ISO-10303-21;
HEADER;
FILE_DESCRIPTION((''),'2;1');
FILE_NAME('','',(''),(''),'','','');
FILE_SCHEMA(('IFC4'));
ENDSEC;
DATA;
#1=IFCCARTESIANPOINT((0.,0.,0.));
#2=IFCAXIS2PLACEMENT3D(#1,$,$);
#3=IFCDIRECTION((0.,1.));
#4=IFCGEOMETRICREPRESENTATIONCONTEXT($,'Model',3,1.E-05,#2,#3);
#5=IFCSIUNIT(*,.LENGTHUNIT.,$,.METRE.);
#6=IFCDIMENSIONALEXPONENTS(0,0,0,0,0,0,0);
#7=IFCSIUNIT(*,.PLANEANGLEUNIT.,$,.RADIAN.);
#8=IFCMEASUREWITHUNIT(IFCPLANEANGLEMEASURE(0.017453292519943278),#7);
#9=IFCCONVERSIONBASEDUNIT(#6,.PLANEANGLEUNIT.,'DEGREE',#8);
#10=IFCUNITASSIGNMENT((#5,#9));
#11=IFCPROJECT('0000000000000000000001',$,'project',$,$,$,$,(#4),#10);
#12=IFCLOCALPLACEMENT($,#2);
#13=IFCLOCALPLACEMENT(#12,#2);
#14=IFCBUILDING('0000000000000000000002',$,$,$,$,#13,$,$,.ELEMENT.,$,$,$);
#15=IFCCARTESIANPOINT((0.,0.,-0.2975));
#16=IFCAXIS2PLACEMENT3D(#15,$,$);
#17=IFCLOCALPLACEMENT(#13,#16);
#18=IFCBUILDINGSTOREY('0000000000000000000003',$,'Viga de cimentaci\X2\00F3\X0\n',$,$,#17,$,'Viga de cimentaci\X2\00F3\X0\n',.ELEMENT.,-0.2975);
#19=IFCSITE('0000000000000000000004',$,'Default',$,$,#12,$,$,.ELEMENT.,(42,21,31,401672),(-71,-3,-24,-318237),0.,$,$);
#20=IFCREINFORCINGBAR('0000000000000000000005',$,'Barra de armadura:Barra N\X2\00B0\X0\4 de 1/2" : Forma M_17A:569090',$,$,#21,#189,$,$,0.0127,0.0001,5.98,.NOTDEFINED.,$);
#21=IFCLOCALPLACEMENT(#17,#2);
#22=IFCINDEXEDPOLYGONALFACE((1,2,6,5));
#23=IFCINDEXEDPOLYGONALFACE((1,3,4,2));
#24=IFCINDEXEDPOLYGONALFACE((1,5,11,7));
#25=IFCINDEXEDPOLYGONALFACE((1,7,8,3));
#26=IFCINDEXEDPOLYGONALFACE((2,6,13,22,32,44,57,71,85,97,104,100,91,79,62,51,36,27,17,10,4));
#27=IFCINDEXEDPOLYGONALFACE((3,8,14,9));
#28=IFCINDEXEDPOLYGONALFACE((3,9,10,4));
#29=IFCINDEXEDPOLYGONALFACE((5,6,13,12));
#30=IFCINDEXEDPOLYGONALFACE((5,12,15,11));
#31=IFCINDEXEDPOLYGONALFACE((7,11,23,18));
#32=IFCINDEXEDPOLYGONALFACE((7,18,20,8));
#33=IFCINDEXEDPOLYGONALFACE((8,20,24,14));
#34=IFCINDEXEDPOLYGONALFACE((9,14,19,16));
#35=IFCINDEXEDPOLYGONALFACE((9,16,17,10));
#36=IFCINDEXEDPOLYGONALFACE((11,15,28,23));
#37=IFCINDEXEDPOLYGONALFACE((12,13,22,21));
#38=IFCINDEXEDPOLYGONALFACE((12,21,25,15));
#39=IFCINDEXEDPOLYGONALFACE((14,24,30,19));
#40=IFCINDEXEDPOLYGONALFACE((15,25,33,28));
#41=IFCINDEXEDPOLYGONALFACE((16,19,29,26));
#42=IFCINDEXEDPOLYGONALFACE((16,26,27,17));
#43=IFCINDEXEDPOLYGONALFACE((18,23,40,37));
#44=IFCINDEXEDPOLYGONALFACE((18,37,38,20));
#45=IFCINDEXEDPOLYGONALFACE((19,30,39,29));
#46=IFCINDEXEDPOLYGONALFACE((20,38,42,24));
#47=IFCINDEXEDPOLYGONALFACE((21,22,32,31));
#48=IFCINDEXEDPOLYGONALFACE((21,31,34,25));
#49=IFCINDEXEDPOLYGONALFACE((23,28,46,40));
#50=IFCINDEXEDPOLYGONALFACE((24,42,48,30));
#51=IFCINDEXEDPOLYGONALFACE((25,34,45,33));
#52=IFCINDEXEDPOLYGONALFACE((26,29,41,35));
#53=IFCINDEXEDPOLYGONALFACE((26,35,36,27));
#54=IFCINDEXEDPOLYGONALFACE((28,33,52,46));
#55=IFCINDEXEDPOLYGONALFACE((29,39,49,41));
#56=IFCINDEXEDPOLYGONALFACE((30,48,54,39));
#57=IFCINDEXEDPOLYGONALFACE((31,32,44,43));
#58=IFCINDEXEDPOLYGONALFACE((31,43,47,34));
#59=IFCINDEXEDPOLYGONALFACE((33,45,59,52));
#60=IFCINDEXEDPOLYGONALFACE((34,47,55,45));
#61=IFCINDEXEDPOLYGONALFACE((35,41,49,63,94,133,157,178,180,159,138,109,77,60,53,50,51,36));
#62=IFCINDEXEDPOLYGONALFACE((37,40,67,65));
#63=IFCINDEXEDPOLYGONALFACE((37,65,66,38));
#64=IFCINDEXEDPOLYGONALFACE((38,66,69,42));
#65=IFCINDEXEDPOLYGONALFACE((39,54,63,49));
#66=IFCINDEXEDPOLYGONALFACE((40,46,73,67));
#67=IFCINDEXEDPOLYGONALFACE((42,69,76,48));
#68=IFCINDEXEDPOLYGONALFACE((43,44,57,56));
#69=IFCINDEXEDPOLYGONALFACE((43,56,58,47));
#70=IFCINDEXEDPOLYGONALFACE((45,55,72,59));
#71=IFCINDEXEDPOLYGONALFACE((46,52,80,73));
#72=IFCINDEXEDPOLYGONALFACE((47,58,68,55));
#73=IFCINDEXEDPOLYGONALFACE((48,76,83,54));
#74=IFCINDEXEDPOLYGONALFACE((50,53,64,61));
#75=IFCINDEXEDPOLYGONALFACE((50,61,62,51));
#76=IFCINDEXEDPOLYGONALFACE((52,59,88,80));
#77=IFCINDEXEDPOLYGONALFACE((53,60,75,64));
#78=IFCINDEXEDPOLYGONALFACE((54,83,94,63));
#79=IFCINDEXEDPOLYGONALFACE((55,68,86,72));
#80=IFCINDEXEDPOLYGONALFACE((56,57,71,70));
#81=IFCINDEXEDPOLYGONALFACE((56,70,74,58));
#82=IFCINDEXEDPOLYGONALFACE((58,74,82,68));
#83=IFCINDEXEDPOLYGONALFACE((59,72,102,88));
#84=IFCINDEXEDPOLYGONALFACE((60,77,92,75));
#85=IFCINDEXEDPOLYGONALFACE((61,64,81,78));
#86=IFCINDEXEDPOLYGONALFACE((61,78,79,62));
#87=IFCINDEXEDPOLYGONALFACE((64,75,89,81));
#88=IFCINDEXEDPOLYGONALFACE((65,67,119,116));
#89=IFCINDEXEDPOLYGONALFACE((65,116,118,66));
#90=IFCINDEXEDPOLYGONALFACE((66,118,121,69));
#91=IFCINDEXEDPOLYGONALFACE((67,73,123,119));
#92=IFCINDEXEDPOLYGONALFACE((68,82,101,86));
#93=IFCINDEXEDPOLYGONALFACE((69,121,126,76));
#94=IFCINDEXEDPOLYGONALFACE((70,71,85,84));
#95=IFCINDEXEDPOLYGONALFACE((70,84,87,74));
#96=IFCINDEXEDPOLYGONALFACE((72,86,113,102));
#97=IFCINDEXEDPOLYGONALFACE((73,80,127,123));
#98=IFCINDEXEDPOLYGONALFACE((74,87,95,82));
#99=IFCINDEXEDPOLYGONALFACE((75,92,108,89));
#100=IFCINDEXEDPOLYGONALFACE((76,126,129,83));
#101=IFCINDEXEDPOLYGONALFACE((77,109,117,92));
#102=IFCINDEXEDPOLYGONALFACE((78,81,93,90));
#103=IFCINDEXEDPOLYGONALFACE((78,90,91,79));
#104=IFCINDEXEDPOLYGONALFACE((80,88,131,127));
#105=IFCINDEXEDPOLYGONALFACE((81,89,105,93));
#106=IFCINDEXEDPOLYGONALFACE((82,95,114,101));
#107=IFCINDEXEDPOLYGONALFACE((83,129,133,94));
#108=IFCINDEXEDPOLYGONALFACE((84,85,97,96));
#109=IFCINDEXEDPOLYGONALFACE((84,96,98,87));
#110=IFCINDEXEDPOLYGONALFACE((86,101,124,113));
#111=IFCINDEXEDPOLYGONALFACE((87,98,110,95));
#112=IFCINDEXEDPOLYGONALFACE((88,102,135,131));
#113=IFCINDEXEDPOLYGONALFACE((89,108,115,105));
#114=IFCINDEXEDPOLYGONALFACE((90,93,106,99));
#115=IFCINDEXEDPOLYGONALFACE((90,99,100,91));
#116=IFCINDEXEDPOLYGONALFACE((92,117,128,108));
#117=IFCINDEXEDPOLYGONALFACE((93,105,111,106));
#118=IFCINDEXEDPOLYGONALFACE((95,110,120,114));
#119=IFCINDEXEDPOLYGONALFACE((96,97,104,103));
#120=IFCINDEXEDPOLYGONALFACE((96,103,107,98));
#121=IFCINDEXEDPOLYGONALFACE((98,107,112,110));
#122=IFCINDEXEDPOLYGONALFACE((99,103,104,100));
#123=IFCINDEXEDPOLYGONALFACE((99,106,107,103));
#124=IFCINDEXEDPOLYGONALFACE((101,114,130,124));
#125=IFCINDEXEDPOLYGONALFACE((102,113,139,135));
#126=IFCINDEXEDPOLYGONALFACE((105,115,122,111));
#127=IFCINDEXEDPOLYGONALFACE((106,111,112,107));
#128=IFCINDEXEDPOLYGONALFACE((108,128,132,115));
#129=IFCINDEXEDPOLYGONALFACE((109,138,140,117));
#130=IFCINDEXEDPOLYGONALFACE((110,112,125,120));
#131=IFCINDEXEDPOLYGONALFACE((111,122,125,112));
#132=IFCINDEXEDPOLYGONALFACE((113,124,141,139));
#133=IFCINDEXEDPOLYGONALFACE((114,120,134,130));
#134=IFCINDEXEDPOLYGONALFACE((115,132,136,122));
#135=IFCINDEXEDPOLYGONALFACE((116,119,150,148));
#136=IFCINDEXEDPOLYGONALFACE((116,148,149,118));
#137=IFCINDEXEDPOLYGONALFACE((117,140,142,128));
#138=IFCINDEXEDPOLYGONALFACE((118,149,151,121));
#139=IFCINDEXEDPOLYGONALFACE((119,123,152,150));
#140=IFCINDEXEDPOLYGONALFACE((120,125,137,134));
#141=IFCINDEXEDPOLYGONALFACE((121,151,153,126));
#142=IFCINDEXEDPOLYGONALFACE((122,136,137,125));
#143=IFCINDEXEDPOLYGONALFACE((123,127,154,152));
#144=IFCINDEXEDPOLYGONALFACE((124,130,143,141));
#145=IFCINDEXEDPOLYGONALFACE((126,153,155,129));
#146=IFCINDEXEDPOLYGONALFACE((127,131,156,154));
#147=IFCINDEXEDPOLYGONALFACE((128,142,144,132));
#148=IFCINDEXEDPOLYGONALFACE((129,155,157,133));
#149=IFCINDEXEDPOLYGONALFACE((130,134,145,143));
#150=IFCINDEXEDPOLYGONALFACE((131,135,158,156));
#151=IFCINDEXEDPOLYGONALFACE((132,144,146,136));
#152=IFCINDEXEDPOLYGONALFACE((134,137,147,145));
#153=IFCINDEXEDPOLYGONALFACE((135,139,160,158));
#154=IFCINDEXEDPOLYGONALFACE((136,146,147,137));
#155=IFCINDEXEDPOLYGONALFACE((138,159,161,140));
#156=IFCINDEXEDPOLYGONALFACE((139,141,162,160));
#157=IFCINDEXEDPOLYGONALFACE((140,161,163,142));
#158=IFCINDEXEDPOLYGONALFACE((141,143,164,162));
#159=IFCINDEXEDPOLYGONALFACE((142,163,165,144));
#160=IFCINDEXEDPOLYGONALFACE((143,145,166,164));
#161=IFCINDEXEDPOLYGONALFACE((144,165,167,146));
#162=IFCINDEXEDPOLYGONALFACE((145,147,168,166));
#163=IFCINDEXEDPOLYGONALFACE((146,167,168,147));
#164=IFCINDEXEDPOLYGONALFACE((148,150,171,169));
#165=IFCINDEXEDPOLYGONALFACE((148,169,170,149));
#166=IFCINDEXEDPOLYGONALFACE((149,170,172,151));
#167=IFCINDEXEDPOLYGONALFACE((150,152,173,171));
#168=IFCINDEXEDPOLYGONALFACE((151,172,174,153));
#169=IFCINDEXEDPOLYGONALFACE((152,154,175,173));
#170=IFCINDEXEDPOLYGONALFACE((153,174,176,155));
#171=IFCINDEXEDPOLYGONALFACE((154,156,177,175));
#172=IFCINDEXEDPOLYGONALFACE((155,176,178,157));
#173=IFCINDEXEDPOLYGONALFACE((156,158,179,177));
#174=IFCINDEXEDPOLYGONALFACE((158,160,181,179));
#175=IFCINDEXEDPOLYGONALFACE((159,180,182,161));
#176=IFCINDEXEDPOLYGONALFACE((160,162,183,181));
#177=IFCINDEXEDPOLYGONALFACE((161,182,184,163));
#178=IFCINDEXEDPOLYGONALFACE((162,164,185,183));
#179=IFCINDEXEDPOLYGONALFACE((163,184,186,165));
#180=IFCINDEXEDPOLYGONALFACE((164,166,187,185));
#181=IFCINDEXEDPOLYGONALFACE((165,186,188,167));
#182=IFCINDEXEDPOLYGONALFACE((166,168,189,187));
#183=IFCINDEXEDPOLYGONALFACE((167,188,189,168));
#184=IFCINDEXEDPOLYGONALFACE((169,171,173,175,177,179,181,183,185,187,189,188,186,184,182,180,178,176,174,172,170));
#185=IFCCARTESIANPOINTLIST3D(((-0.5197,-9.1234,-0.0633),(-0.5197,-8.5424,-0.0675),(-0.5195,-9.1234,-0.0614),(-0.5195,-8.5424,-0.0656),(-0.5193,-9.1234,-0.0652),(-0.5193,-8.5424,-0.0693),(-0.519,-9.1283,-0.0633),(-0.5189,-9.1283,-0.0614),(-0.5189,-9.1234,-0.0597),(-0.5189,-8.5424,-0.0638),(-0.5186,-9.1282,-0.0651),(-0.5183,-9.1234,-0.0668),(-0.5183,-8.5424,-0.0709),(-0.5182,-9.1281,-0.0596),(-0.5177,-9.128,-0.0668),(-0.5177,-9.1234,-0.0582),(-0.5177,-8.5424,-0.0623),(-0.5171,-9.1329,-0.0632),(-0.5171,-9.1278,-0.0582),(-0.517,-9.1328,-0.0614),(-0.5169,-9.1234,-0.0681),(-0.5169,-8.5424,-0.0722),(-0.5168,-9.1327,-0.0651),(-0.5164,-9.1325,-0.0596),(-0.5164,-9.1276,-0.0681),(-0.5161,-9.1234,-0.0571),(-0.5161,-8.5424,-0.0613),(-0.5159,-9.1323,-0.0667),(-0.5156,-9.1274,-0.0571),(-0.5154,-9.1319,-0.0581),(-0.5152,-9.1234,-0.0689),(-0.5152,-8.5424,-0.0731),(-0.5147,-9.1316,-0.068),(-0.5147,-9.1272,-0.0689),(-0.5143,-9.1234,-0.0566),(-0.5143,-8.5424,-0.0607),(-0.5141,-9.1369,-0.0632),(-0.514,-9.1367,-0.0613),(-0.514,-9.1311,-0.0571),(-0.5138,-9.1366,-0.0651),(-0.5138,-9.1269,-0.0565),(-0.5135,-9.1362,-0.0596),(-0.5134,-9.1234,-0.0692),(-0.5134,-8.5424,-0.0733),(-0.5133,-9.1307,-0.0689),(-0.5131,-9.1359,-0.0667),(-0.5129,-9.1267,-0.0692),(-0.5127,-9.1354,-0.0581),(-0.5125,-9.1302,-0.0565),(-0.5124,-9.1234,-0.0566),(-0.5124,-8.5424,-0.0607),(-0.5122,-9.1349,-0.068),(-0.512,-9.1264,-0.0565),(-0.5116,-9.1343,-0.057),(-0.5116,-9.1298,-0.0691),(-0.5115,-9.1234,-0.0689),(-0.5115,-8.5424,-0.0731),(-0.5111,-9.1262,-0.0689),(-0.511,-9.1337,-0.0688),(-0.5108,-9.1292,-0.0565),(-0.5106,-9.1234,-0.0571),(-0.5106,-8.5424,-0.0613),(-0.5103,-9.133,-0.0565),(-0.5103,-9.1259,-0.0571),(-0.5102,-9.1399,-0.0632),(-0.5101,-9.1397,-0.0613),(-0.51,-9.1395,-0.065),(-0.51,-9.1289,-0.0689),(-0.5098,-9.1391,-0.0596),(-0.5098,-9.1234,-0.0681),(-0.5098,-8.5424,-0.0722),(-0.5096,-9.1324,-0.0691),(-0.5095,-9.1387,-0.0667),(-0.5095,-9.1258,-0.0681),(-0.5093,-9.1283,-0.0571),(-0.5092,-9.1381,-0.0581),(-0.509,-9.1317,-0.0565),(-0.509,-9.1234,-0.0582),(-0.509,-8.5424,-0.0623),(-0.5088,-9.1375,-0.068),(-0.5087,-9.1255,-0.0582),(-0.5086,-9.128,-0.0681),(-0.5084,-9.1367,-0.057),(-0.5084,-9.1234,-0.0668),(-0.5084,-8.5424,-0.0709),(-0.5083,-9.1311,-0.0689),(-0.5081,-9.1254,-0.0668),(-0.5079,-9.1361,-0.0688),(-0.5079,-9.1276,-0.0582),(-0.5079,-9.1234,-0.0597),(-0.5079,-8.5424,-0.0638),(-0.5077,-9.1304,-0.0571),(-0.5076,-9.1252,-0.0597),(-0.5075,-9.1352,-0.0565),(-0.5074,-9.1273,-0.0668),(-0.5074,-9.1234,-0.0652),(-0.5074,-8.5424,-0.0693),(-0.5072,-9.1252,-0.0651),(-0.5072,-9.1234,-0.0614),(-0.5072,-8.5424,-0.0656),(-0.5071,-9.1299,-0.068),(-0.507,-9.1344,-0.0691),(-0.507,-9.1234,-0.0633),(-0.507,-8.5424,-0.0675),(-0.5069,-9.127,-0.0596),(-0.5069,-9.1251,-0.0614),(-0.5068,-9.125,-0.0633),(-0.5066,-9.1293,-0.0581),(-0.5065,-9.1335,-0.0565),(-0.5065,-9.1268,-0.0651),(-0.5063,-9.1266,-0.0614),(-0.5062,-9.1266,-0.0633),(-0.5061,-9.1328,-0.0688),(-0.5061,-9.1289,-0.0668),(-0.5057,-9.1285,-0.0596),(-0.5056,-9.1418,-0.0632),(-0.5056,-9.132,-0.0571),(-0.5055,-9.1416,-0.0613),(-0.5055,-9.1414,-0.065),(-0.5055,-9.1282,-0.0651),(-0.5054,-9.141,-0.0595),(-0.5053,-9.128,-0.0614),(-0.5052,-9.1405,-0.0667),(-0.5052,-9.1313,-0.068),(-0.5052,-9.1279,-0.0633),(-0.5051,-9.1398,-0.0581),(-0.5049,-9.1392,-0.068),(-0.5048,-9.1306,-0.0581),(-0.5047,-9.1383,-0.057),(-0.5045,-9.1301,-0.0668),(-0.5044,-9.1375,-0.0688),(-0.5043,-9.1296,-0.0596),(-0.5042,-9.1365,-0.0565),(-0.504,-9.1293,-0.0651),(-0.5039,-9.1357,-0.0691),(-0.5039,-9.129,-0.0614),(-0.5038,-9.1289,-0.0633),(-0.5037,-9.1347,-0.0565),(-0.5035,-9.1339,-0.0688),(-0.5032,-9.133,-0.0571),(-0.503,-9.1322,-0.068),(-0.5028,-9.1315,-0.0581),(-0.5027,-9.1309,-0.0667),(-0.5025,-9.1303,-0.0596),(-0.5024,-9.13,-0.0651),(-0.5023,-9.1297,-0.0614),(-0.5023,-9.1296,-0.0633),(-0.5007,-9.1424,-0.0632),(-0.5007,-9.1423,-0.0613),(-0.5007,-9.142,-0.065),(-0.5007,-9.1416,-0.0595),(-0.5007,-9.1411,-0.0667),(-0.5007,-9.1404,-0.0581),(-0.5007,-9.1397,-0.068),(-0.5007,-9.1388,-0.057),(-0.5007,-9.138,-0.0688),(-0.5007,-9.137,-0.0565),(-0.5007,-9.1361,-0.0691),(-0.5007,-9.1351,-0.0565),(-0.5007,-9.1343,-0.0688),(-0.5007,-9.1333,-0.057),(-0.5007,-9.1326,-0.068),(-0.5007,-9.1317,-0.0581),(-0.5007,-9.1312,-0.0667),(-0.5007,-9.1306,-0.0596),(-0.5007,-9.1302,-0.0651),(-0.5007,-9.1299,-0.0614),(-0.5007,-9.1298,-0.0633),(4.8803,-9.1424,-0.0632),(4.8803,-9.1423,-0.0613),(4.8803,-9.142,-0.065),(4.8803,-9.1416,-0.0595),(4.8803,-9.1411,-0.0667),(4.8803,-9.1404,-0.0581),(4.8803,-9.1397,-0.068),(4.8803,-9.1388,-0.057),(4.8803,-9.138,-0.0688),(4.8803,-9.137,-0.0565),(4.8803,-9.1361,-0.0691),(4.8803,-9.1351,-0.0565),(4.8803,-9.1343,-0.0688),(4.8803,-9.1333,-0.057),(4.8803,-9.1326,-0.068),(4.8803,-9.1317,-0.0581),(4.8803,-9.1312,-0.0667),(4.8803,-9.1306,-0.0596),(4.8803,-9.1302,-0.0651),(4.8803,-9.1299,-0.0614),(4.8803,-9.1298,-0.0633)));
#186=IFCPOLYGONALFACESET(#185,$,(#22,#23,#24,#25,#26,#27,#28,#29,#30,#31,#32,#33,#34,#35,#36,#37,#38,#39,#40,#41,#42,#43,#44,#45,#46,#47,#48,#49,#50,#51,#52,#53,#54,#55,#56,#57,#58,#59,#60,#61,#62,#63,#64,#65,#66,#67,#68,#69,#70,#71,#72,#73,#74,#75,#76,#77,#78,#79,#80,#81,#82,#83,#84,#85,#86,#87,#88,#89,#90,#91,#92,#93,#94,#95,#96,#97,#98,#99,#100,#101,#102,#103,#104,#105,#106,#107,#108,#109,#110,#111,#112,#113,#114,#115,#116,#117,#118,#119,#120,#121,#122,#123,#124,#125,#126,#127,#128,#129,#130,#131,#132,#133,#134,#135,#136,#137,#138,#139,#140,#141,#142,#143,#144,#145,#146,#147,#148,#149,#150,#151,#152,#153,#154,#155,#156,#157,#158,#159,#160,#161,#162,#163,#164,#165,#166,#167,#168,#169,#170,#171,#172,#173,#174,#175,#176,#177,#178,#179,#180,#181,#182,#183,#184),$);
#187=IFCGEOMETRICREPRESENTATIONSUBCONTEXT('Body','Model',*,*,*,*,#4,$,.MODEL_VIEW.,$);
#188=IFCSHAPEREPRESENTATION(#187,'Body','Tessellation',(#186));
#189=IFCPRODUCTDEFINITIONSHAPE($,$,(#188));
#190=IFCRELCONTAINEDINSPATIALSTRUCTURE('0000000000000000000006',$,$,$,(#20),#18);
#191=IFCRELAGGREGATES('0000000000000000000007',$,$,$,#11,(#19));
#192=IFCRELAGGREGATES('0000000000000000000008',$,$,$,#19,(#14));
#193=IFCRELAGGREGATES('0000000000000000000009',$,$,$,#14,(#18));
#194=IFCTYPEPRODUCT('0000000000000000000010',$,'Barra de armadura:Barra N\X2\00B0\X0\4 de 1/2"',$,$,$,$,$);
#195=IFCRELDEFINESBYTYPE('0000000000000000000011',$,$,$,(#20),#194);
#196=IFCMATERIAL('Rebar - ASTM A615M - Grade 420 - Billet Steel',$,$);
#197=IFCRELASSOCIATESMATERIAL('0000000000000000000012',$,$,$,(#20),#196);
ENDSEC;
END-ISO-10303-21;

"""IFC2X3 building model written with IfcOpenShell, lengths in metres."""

from ifc_helpers import new_model, entity, si_unit, converted_unit, direction, frame, origin, place, context, subcontext, project, spatial, material, type_object, element, save


model = new_model("IFC2X3")

# Units and contexts
model_context = context("Model", 3, precision=1e-05, world=origin(), true_north=direction((0.0, 1.0)))
body_context = subcontext(model_context, "Body", "Model", "MODEL_VIEW")
ifc_project = project(units=[si_unit("LENGTHUNIT", "METRE"), converted_unit("PLANEANGLEUNIT", "DEGREE", entity("IfcPlaneAngleMeasure", 0.017453292519943278), si_unit("PLANEANGLEUNIT", "RADIAN"), dimensions=[0, 0, 0, 0, 0, 0, 0])], contexts=[model_context])

# Site, building, storey
site_placement = place(None, origin())
site = spatial("IfcSite", under=ifc_project, at=site_placement, Name="Default", CompositionType="ELEMENT", RefLatitude=(42, 21, 31, 401672), RefLongitude=(-71, -3, -24, -318237), RefElevation=0.0)
building_placement = place(site_placement, origin())
building = spatial("IfcBuilding", under=site, at=building_placement, CompositionType="ELEMENT")
storey_placement = place(building_placement, frame((0.0, 0.0, -0.2975)))
storey = spatial("IfcBuildingStorey", under=building, at=storey_placement, Name="Viga de cimentación", LongName="Viga de cimentación", CompositionType="ELEMENT", Elevation=-0.2975)

# Reinforcing bar
ifc_material = material(Name="Rebar - ASTM A615M - Grade 420 - Billet Steel")
type_product_1 = type_object("IfcTypeProduct", Name="Barra de armadura:Barra N°4 de 1/2\"")
reinforcing_bar_1_placement = place(storey_placement, origin())
element("IfcReinforcingBar", 1, at=reinforcing_bar_1_placement, inside=storey, type_object=type_product_1, material=ifc_material, Name="Barra de armadura:Barra N°4 de 1/2\" : Forma M_17A:569090", BarLength=5.98, BarRole="NOTDEFINED", CrossSectionArea=0.0001, NominalDiameter=0.0127, context=body_context, shape_type="AdvancedSweptSolid", body=[
    entity("IfcSweptDiskSolid", entity("IfcCompositeCurve", [entity("IfcCompositeCurveSegment", "CONTINUOUS", True, entity("IfcPolyline", [entity("IfcCartesianPoint", [-0.5134, -8.5424, -0.067]), entity("IfcCartesianPoint", [-0.5134, -9.1234, -0.0628])])), entity("IfcCompositeCurveSegment", "CONTINUOUS", True, entity("IfcTrimmedCurve", entity("IfcCircle", entity("IfcAxis2Placement3D", entity("IfcCartesianPoint", [-0.5007, -9.1234, -0.0628]), entity("IfcDirection", [0.0, 0.007141, 0.999975]), entity("IfcDirection", [0.0, -0.999975, 0.007141])), 0.0127), [entity("IfcParameterValue", 270.0)], [entity("IfcParameterValue", 360.0)], True, "PARAMETER")), entity("IfcCompositeCurveSegment", "CONTINUOUS", True, entity("IfcPolyline", [entity("IfcCartesianPoint", [-0.5007, -9.1361, -0.0627]), entity("IfcCartesianPoint", [4.8803, -9.1361, -0.0627])]))], False), 0.0063, None, 0.0, 92.0),
])

save(model, "model.ifc")
